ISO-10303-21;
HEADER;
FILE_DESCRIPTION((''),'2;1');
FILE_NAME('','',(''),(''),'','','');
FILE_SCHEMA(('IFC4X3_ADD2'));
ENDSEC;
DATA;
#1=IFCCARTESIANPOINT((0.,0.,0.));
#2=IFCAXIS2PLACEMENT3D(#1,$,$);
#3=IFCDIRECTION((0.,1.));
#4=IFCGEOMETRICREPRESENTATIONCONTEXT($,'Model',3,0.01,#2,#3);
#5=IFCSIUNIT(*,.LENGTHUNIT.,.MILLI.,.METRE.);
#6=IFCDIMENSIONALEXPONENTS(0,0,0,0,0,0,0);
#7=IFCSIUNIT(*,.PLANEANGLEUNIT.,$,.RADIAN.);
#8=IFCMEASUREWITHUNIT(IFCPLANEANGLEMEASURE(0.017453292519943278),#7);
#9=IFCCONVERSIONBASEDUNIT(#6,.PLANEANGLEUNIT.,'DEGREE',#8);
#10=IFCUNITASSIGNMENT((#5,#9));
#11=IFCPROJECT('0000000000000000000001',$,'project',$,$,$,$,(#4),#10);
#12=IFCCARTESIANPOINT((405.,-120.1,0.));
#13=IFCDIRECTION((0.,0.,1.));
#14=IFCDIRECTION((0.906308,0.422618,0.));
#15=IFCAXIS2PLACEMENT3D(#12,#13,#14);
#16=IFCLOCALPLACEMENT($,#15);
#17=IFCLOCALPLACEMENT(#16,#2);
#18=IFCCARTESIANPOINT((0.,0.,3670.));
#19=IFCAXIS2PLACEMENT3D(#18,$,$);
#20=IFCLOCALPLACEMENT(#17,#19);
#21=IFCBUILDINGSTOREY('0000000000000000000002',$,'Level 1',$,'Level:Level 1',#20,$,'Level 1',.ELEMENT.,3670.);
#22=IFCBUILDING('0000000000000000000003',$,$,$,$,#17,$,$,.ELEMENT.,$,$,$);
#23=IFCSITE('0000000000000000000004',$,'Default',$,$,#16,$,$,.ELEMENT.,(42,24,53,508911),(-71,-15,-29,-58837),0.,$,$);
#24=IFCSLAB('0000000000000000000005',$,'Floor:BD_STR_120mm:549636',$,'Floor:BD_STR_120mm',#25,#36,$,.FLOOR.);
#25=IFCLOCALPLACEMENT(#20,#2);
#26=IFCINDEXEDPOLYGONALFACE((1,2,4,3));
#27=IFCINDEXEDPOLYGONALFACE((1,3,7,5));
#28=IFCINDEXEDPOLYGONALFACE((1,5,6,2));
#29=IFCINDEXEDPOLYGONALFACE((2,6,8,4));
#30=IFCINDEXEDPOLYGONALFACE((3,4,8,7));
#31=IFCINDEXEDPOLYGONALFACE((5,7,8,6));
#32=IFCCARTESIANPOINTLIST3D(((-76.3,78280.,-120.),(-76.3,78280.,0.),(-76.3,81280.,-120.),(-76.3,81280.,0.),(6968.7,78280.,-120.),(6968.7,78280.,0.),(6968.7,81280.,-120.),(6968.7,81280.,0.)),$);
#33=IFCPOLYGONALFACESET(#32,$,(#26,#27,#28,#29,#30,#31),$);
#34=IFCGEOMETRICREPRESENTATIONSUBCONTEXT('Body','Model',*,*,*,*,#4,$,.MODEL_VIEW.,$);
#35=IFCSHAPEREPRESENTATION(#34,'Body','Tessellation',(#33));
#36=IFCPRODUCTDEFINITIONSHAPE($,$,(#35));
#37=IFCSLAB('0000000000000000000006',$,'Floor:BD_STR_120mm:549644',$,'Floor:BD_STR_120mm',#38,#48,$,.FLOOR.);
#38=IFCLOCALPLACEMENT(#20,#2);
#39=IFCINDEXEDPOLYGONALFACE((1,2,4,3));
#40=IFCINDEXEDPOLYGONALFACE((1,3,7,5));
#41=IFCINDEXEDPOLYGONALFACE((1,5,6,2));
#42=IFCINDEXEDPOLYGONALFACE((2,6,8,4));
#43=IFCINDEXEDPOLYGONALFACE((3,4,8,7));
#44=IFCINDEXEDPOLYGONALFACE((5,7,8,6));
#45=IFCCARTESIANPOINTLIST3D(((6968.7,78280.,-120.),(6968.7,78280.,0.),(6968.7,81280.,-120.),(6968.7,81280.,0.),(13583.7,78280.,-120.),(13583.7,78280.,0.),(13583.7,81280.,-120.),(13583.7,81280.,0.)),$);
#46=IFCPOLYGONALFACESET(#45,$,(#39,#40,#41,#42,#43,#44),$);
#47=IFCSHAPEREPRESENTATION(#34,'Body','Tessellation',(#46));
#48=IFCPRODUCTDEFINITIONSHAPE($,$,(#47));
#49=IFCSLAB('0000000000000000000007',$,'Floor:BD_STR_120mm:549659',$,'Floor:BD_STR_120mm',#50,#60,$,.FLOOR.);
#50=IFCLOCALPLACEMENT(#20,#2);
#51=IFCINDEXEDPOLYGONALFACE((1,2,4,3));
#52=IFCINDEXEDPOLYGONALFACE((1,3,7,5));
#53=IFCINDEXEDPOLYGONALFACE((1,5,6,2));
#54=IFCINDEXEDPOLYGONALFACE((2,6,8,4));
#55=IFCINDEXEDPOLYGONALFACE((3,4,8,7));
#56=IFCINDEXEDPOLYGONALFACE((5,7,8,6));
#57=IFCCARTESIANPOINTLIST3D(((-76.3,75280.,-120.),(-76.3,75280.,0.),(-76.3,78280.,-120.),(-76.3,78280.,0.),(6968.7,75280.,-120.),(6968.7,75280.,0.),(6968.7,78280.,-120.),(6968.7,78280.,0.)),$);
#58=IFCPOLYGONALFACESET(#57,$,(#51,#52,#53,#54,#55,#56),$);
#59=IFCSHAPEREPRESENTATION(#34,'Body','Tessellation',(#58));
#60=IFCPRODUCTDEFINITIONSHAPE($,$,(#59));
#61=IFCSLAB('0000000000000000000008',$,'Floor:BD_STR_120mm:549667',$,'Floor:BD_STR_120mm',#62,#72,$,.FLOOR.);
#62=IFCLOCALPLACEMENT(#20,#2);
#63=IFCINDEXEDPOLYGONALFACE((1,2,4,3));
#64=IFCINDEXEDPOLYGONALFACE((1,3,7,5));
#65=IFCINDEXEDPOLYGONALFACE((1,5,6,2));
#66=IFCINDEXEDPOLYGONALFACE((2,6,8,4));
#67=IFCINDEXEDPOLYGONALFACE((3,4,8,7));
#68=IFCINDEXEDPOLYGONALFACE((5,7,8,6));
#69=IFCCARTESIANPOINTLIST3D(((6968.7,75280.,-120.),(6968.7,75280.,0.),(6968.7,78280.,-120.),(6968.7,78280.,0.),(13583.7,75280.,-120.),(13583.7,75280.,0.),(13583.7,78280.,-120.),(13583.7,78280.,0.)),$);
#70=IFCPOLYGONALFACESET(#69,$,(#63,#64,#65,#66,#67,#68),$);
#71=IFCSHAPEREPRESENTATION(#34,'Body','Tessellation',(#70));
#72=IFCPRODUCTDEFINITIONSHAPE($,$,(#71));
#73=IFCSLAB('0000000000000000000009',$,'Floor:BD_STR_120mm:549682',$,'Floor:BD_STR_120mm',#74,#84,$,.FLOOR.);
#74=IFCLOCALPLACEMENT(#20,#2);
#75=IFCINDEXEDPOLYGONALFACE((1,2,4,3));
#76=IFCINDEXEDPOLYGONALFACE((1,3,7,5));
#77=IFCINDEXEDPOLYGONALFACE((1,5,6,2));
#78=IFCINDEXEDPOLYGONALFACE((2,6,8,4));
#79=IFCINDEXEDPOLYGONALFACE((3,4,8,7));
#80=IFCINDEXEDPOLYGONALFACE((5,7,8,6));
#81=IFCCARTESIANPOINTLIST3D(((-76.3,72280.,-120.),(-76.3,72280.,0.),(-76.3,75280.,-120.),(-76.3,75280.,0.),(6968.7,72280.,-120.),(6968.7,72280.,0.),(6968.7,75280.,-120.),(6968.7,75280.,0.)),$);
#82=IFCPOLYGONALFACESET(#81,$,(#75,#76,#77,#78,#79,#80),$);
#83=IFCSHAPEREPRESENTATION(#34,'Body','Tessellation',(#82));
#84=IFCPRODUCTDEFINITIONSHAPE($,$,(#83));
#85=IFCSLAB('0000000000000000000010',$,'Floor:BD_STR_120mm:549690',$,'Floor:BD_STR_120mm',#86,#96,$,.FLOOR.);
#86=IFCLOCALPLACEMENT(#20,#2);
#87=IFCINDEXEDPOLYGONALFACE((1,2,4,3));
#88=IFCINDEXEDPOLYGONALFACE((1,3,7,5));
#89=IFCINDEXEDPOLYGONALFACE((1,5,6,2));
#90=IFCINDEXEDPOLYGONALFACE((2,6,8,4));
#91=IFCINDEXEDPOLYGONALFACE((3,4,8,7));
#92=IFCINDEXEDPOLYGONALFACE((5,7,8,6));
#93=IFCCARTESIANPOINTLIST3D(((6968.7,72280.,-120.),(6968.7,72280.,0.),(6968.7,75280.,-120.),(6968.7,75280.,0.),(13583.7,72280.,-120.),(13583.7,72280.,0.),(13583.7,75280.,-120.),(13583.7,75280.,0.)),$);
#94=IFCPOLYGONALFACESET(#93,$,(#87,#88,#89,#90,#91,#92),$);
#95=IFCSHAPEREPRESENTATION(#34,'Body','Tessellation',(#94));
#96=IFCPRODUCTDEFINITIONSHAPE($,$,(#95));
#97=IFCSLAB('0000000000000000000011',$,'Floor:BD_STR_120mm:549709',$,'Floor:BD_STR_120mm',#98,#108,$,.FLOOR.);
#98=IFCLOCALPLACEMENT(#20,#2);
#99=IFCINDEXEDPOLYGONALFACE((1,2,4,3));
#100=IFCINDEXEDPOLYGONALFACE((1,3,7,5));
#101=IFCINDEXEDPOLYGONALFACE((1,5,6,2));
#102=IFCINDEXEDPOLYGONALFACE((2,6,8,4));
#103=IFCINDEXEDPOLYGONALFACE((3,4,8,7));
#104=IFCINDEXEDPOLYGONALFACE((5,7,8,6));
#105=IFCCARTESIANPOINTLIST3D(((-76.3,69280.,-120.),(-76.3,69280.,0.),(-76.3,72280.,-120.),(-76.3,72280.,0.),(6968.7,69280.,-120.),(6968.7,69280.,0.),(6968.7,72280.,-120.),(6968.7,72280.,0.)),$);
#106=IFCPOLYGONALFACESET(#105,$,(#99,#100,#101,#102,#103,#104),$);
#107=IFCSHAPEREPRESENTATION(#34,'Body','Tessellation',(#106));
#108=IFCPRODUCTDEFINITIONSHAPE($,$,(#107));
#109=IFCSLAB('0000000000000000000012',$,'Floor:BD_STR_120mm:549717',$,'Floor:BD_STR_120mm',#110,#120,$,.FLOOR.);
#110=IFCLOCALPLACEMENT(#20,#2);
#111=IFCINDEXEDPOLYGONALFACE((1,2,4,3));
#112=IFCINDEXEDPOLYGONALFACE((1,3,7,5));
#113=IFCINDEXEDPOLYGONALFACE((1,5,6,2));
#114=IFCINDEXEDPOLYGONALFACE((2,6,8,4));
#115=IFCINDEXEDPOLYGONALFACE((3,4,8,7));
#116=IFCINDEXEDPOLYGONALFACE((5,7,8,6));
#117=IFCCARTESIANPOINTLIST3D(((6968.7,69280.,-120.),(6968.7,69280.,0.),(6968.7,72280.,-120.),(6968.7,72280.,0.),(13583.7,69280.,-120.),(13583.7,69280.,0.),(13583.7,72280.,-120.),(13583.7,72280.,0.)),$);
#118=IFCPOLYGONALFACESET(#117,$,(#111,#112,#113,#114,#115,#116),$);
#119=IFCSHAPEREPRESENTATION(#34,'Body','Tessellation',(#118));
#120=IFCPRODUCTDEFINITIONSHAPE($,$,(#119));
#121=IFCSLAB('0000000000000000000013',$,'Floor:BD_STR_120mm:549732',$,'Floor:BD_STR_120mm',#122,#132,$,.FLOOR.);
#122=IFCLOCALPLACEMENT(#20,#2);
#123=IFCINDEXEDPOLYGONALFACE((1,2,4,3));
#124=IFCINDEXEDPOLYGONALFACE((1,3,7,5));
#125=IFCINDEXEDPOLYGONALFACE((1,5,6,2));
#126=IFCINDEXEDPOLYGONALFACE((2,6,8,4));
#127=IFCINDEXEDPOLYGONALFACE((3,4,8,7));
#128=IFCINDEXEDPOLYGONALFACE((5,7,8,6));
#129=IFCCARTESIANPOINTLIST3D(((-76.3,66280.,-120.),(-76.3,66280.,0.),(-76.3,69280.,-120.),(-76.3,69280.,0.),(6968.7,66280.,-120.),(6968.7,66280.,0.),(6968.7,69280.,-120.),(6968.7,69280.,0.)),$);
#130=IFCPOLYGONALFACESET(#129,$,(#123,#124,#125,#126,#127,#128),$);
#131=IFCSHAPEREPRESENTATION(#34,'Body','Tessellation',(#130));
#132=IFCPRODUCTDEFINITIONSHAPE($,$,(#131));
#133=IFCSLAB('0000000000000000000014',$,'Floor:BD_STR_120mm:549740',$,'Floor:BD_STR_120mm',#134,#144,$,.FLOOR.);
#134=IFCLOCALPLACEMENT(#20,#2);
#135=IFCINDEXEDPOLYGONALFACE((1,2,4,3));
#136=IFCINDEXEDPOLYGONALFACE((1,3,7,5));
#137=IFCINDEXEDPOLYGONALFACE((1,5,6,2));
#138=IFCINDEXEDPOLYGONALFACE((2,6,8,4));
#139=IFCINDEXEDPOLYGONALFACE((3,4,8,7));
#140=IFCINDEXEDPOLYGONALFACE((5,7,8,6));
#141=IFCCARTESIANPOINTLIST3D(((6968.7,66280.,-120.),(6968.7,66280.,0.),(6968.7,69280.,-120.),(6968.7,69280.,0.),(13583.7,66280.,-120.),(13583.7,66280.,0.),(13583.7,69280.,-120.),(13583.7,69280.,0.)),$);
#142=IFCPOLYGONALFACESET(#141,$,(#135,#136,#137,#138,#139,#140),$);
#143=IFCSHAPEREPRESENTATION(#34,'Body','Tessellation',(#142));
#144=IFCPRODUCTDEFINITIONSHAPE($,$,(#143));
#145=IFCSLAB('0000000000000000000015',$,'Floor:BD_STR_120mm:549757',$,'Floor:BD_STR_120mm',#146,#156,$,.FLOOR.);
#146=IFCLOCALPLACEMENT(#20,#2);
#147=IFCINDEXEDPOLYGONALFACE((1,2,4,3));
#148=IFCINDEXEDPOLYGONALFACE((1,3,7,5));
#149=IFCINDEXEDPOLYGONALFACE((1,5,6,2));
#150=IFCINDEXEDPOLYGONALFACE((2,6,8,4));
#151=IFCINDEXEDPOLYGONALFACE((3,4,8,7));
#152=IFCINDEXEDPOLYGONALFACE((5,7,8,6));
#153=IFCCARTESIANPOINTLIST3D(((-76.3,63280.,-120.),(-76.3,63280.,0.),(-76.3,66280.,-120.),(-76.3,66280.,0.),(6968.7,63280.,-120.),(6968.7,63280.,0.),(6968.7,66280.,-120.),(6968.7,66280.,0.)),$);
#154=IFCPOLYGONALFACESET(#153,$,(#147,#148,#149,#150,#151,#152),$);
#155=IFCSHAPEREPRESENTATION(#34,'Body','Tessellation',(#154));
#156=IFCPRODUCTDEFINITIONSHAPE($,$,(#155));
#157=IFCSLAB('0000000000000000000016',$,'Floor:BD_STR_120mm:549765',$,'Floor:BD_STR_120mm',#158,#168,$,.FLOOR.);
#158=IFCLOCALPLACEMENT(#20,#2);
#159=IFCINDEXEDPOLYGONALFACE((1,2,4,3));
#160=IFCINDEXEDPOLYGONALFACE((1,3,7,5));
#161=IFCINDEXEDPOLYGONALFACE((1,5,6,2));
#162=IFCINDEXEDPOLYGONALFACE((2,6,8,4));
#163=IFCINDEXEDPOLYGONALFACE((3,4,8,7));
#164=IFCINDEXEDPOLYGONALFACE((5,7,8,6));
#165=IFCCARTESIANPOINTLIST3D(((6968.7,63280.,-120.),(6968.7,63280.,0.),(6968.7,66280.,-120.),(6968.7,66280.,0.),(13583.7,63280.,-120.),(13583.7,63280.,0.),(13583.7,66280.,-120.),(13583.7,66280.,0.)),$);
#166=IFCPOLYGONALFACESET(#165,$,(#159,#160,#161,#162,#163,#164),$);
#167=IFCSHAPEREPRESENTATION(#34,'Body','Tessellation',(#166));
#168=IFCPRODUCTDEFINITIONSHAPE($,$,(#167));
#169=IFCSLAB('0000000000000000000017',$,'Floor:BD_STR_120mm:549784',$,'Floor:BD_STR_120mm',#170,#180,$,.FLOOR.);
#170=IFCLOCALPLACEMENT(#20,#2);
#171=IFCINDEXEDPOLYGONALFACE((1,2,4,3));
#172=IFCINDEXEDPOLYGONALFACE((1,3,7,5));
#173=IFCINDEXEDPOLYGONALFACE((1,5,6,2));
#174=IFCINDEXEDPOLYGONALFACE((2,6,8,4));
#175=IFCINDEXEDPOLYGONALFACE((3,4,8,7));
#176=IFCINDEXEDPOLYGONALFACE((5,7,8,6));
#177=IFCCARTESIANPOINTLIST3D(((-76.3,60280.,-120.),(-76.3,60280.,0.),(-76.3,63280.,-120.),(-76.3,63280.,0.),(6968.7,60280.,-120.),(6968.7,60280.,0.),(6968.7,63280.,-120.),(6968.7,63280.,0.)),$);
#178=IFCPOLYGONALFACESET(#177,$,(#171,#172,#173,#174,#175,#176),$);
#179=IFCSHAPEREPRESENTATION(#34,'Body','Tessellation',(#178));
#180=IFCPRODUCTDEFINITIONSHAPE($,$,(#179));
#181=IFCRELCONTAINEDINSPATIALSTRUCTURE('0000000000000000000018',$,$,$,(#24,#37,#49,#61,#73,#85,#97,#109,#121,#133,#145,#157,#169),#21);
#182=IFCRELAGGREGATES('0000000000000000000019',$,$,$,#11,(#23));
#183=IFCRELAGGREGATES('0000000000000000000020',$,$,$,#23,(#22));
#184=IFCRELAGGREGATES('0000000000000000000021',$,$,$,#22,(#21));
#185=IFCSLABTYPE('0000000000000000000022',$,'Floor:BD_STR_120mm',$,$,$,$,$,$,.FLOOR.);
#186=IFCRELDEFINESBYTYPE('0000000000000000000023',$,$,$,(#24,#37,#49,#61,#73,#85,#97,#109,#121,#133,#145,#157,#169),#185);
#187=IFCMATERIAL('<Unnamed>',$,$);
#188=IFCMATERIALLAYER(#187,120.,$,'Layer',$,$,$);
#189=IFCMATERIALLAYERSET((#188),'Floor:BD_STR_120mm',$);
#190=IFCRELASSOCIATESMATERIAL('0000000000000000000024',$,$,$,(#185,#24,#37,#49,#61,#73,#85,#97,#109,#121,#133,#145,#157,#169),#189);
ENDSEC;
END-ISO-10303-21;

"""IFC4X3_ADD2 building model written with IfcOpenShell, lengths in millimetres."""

from ifc_helpers import new_model, entity, si_unit, converted_unit, direction, frame, frame_2d, origin, origin_2d_with_axis, place, context, subcontext, project, spatial, rectangle, extrude, material, layer, layer_set, layer_usage, type_object, element, save


model = new_model("IFC4X3_ADD2")

# Units and contexts
model_context = context("Model", 3, precision=0.01, world=origin(), true_north=direction((0.0, 1.0)))
body_context = subcontext(model_context, "Body", "Model", "MODEL_VIEW")
ifc_project = project(units=[si_unit("LENGTHUNIT", "METRE", prefix="MILLI"), converted_unit("PLANEANGLEUNIT", "DEGREE", entity("IfcPlaneAngleMeasure", 0.017453292519943278), si_unit("PLANEANGLEUNIT", "RADIAN"), dimensions=[0, 0, 0, 0, 0, 0, 0])], contexts=[model_context])

# Site, building, storey
site_placement = place(None, frame((405.0, -120.1, 0.0), z_axis=(0.0, 0.0, 1.0), x_axis=(0.906308, 0.422618, 0.0)))
site = spatial("IfcSite", under=ifc_project, at=site_placement, Name="Default", CompositionType="ELEMENT", RefLatitude=(42, 24, 53, 508911), RefLongitude=(-71, -15, -29, -58837), RefElevation=0.0)
building_placement = place(site_placement, origin())
building = spatial("IfcBuilding", under=site, at=building_placement, CompositionType="ELEMENT")
storey_placement = place(building_placement, frame((0.0, 0.0, 3670.0)))
storey = spatial("IfcBuildingStorey", under=building, at=storey_placement, Name="Level 1", ObjectType="Level:Level 1", LongName="Level 1", CompositionType="ELEMENT", Elevation=3670.0)

# Slabs
ifc_material_1 = material(Name="<Unnamed>")
ifc_layer = layer(ifc_material_1, 120.0, Name="Layer")
ifc_layer_set = layer_set([ifc_layer], Name="Floor:BD_STR_120mm")
slab_type = type_object("IfcSlabType", Name="Floor:BD_STR_120mm", PredefinedType="FLOOR", material=ifc_layer_set)
ifc_layer_usage_1 = layer_usage(ifc_layer_set, "AXIS3", "POSITIVE", 0.0)
slab_1_placement = place(storey_placement, origin())
element("IfcSlab", 1, at=slab_1_placement, inside=storey, type_object=slab_type, material=ifc_layer_usage_1, Name="Floor:BD_STR_120mm:549636", ObjectType="Floor:BD_STR_120mm", PredefinedType="FLOOR", context=body_context, shape_type="SweptSolid", body=[
    extrude(rectangle(XDim=3000.0, YDim=7045.0, at=frame_2d((0.0, 0.0), x_axis=(1.0, 0.0))), frame((3446.2, 79780.0, 0.0), z_axis=(0.0, 0.0, -1.0), x_axis=(0.0, 1.0, 0.0)), (0.0, 0.0, 1.0), 120.0),
])
ifc_layer_usage_2 = layer_usage(ifc_layer_set, "AXIS3", "POSITIVE", 0.0)
slab_2_placement = place(storey_placement, origin())
element("IfcSlab", 2, at=slab_2_placement, inside=storey, type_object=slab_type, material=ifc_layer_usage_2, Name="Floor:BD_STR_120mm:549644", ObjectType="Floor:BD_STR_120mm", PredefinedType="FLOOR", context=body_context, shape_type="SweptSolid", body=[
    extrude(rectangle(XDim=3000.0, YDim=6615.0, at=origin_2d_with_axis()), frame((10276.2, 79780.0, 0.0), z_axis=(0.0, 0.0, -1.0), x_axis=(0.0, 1.0, 0.0)), (0.0, 0.0, 1.0), 120.0),
])
ifc_layer_usage_3 = layer_usage(ifc_layer_set, "AXIS3", "POSITIVE", 0.0)
slab_3_placement = place(storey_placement, origin())
element("IfcSlab", 3, at=slab_3_placement, inside=storey, type_object=slab_type, material=ifc_layer_usage_3, Name="Floor:BD_STR_120mm:549659", ObjectType="Floor:BD_STR_120mm", PredefinedType="FLOOR", context=body_context, shape_type="SweptSolid", body=[
    extrude(rectangle(XDim=3000.0, YDim=7045.0, at=frame_2d((0.0, 0.0), x_axis=(1.0, 0.0))), frame((3446.2, 76780.0, 0.0), z_axis=(0.0, 0.0, -1.0), x_axis=(0.0, 1.0, 0.0)), (0.0, 0.0, 1.0), 120.0),
])
ifc_layer_usage_4 = layer_usage(ifc_layer_set, "AXIS3", "POSITIVE", 0.0)
slab_4_placement = place(storey_placement, origin())
element("IfcSlab", 4, at=slab_4_placement, inside=storey, type_object=slab_type, material=ifc_layer_usage_4, Name="Floor:BD_STR_120mm:549667", ObjectType="Floor:BD_STR_120mm", PredefinedType="FLOOR", context=body_context, shape_type="SweptSolid", body=[
    extrude(rectangle(XDim=3000.0, YDim=6615.0, at=frame_2d((0.0, 0.0), x_axis=(1.0, 0.0))), frame((10276.2, 76780.0, 0.0), z_axis=(0.0, 0.0, -1.0), x_axis=(0.0, 1.0, 0.0)), (0.0, 0.0, 1.0), 120.0),
])
ifc_layer_usage_5 = layer_usage(ifc_layer_set, "AXIS3", "POSITIVE", 0.0)
slab_5_placement = place(storey_placement, origin())
element("IfcSlab", 5, at=slab_5_placement, inside=storey, type_object=slab_type, material=ifc_layer_usage_5, Name="Floor:BD_STR_120mm:549682", ObjectType="Floor:BD_STR_120mm", PredefinedType="FLOOR", context=body_context, shape_type="SweptSolid", body=[
    extrude(rectangle(XDim=3000.0, YDim=7045.0, at=frame_2d((0.0, 0.0), x_axis=(1.0, 0.0))), frame((3446.2, 73780.0, 0.0), z_axis=(0.0, 0.0, -1.0), x_axis=(0.0, 1.0, 0.0)), (0.0, 0.0, 1.0), 120.0),
])
ifc_layer_usage_6 = layer_usage(ifc_layer_set, "AXIS3", "POSITIVE", 0.0)
slab_6_placement = place(storey_placement, origin())
element("IfcSlab", 6, at=slab_6_placement, inside=storey, type_object=slab_type, material=ifc_layer_usage_6, Name="Floor:BD_STR_120mm:549690", ObjectType="Floor:BD_STR_120mm", PredefinedType="FLOOR", context=body_context, shape_type="SweptSolid", body=[
    extrude(rectangle(XDim=3000.0, YDim=6615.0, at=frame_2d((0.0, 0.0), x_axis=(1.0, 0.0))), frame((10276.2, 73780.0, 0.0), z_axis=(0.0, 0.0, -1.0), x_axis=(0.0, 1.0, 0.0)), (0.0, 0.0, 1.0), 120.0),
])
ifc_layer_usage_7 = layer_usage(ifc_layer_set, "AXIS3", "POSITIVE", 0.0)
slab_7_placement = place(storey_placement, origin())
element("IfcSlab", 7, at=slab_7_placement, inside=storey, type_object=slab_type, material=ifc_layer_usage_7, Name="Floor:BD_STR_120mm:549709", ObjectType="Floor:BD_STR_120mm", PredefinedType="FLOOR", context=body_context, shape_type="SweptSolid", body=[
    extrude(rectangle(XDim=3000.0, YDim=7045.0, at=frame_2d((0.0, 0.0), x_axis=(1.0, 0.0))), frame((3446.2, 70780.0, 0.0), z_axis=(0.0, 0.0, -1.0), x_axis=(0.0, 1.0, 0.0)), (0.0, 0.0, 1.0), 120.0),
])
ifc_layer_usage_8 = layer_usage(ifc_layer_set, "AXIS3", "POSITIVE", 0.0)
slab_8_placement = place(storey_placement, origin())
element("IfcSlab", 8, at=slab_8_placement, inside=storey, type_object=slab_type, material=ifc_layer_usage_8, Name="Floor:BD_STR_120mm:549717", ObjectType="Floor:BD_STR_120mm", PredefinedType="FLOOR", context=body_context, shape_type="SweptSolid", body=[
    extrude(rectangle(XDim=3000.0, YDim=6615.0, at=frame_2d((0.0, 0.0), x_axis=(1.0, 0.0))), frame((10276.2, 70780.0, 0.0), z_axis=(0.0, 0.0, -1.0), x_axis=(0.0, 1.0, 0.0)), (0.0, 0.0, 1.0), 120.0),
])
ifc_layer_usage_9 = layer_usage(ifc_layer_set, "AXIS3", "POSITIVE", 0.0)
slab_9_placement = place(storey_placement, origin())
element("IfcSlab", 9, at=slab_9_placement, inside=storey, type_object=slab_type, material=ifc_layer_usage_9, Name="Floor:BD_STR_120mm:549732", ObjectType="Floor:BD_STR_120mm", PredefinedType="FLOOR", context=body_context, shape_type="SweptSolid", body=[
    extrude(rectangle(XDim=3000.0, YDim=7045.0, at=frame_2d((0.0, 0.0), x_axis=(1.0, 0.0))), frame((3446.2, 67780.0, 0.0), z_axis=(0.0, 0.0, -1.0), x_axis=(0.0, 1.0, 0.0)), (0.0, 0.0, 1.0), 120.0),
])
ifc_layer_usage_10 = layer_usage(ifc_layer_set, "AXIS3", "POSITIVE", 0.0)
slab_10_placement = place(storey_placement, origin())
element("IfcSlab", 10, at=slab_10_placement, inside=storey, type_object=slab_type, material=ifc_layer_usage_10, Name="Floor:BD_STR_120mm:549740", ObjectType="Floor:BD_STR_120mm", PredefinedType="FLOOR", context=body_context, shape_type="SweptSolid", body=[
    extrude(rectangle(XDim=3000.0, YDim=6615.0, at=frame_2d((0.0, 0.0), x_axis=(1.0, 0.0))), frame((10276.2, 67780.0, 0.0), z_axis=(0.0, 0.0, -1.0), x_axis=(0.0, 1.0, 0.0)), (0.0, 0.0, 1.0), 120.0),
])
ifc_layer_usage_11 = layer_usage(ifc_layer_set, "AXIS3", "POSITIVE", 0.0)
slab_11_placement = place(storey_placement, origin())
element("IfcSlab", 11, at=slab_11_placement, inside=storey, type_object=slab_type, material=ifc_layer_usage_11, Name="Floor:BD_STR_120mm:549757", ObjectType="Floor:BD_STR_120mm", PredefinedType="FLOOR", context=body_context, shape_type="SweptSolid", body=[
    extrude(rectangle(XDim=3000.0, YDim=7045.0, at=frame_2d((0.0, 0.0), x_axis=(1.0, 0.0))), frame((3446.2, 64780.0, 0.0), z_axis=(0.0, 0.0, -1.0), x_axis=(0.0, 1.0, 0.0)), (0.0, 0.0, 1.0), 120.0),
])
ifc_layer_usage_12 = layer_usage(ifc_layer_set, "AXIS3", "POSITIVE", 0.0)
slab_12_placement = place(storey_placement, origin())
element("IfcSlab", 12, at=slab_12_placement, inside=storey, type_object=slab_type, material=ifc_layer_usage_12, Name="Floor:BD_STR_120mm:549765", ObjectType="Floor:BD_STR_120mm", PredefinedType="FLOOR", context=body_context, shape_type="SweptSolid", body=[
    extrude(rectangle(XDim=3000.0, YDim=6615.0, at=frame_2d((0.0, 0.0), x_axis=(1.0, 0.0))), frame((10276.2, 64780.0, 0.0), z_axis=(0.0, 0.0, -1.0), x_axis=(0.0, 1.0, 0.0)), (0.0, 0.0, 1.0), 120.0),
])
ifc_layer_usage_13 = layer_usage(ifc_layer_set, "AXIS3", "POSITIVE", 0.0)
slab_13_placement = place(storey_placement, origin())
element("IfcSlab", 13, at=slab_13_placement, inside=storey, type_object=slab_type, material=ifc_layer_usage_13, Name="Floor:BD_STR_120mm:549784", ObjectType="Floor:BD_STR_120mm", PredefinedType="FLOOR", context=body_context, shape_type="SweptSolid", body=[
    extrude(rectangle(XDim=3000.0, YDim=7045.0, at=frame_2d((0.0, 0.0), x_axis=(1.0, 0.0))), frame((3446.2, 61780.0, 0.0), z_axis=(0.0, 0.0, -1.0), x_axis=(0.0, 1.0, 0.0)), (0.0, 0.0, 1.0), 120.0),
])

save(model, "model.ifc")
